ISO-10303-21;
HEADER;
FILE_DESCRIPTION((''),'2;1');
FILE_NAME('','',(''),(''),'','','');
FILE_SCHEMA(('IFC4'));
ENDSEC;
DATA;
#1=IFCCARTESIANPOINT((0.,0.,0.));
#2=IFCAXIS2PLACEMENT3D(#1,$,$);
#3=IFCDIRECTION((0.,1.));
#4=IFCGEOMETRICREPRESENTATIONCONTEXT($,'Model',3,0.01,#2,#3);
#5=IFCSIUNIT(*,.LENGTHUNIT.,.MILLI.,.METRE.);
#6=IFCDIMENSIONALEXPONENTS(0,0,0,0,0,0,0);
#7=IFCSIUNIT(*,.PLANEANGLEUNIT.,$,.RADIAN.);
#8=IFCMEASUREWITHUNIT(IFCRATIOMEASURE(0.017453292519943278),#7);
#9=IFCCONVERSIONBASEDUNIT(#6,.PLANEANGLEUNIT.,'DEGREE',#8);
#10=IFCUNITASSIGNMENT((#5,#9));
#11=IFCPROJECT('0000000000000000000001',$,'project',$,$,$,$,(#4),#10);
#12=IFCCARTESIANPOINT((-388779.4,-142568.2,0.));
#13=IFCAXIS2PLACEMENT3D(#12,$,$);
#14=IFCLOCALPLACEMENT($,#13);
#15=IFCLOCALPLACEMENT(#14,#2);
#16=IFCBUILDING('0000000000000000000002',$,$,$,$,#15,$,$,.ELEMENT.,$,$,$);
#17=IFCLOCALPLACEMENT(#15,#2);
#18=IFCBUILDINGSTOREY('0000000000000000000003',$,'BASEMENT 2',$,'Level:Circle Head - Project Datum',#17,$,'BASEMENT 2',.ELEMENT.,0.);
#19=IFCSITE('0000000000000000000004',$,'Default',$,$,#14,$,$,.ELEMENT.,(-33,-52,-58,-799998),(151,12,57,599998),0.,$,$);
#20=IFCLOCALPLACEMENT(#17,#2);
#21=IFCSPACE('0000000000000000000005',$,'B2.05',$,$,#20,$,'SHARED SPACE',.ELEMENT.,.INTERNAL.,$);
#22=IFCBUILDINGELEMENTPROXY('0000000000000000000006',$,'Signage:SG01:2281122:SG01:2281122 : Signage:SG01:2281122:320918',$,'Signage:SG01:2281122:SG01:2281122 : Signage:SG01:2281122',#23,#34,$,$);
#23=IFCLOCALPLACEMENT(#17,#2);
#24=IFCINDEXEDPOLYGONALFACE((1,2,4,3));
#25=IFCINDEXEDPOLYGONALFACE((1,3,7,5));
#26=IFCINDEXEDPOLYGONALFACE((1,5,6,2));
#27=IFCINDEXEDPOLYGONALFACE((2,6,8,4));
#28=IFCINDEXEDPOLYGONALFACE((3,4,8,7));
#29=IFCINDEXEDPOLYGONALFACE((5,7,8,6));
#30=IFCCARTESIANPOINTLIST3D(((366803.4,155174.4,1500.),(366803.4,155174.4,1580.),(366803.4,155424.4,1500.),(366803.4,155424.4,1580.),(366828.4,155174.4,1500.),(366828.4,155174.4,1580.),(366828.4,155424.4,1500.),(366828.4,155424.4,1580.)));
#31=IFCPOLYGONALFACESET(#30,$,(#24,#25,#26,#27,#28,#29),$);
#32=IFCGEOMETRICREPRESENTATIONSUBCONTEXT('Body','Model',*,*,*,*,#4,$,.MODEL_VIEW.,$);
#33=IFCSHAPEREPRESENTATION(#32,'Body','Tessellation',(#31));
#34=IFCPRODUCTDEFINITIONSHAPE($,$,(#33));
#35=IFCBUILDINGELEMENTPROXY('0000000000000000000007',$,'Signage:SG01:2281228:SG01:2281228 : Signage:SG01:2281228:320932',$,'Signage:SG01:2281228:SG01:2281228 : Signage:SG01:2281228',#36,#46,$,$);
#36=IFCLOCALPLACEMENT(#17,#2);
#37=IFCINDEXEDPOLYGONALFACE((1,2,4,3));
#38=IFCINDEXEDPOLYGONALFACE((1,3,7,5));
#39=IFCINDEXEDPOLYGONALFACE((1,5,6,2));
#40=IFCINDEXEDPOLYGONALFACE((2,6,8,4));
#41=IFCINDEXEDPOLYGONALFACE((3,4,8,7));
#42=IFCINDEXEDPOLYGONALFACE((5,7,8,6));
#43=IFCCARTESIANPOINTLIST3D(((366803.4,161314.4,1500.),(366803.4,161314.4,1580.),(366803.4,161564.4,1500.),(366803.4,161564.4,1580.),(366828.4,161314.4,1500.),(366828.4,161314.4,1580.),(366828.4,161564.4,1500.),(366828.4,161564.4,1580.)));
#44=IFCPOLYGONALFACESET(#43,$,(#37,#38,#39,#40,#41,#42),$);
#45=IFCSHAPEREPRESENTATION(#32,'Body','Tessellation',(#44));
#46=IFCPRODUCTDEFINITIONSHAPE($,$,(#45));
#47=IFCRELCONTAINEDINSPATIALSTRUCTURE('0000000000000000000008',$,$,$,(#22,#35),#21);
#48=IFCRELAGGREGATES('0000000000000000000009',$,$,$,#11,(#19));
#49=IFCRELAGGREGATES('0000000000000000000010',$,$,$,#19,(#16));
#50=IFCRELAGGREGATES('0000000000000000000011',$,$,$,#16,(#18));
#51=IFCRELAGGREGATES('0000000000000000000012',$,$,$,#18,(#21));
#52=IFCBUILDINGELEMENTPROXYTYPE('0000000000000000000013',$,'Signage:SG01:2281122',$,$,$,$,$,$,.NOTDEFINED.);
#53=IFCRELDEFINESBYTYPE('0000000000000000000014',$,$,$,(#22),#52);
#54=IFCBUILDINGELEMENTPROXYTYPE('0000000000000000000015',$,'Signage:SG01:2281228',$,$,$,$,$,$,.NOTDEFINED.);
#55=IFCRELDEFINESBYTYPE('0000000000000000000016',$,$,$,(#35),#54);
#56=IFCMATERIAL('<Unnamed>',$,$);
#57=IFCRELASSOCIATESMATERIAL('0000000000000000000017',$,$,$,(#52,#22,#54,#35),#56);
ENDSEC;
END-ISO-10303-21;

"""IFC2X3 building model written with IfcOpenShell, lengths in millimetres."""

from ifc_helpers import new_model, entity, si_unit, converted_unit, direction, frame, frame_2d, origin, place, context, subcontext, project, spatial, rectangle, extrude, source, transform, mapped, material, type_object, type_shapes, element, save


model = new_model("IFC2X3")

# Units and contexts
model_context = context("Model", 3, precision=0.01, world=origin(), true_north=direction((0.0, 1.0)))
body_context = subcontext(model_context, "Body", "Model", "MODEL_VIEW")
ifc_project = project(units=[si_unit("LENGTHUNIT", "METRE", prefix="MILLI"), converted_unit("PLANEANGLEUNIT", "DEGREE", entity("IfcRatioMeasure", 0.017453292519943278), si_unit("PLANEANGLEUNIT", "RADIAN"), dimensions=[0, 0, 0, 0, 0, 0, 0])], contexts=[model_context])

# Site, building, storey
site_placement = place(None, frame((-388779.4, -142568.2, 0.0)))
site = spatial("IfcSite", under=ifc_project, at=site_placement, Name="Default", CompositionType="ELEMENT", RefLatitude=(-33, -52, -58, -799998), RefLongitude=(151, 12, 57, 599998), RefElevation=0.0)
building_placement = place(site_placement, origin())
building = spatial("IfcBuilding", under=site, at=building_placement, CompositionType="ELEMENT")
storey_placement = place(building_placement, origin())
storey = spatial("IfcBuildingStorey", under=building, at=storey_placement, Name="BASEMENT 2", ObjectType="Level:Circle Head - Project Datum", LongName="BASEMENT 2", CompositionType="ELEMENT", Elevation=0.0)

# Shared definitions
ifc_material_1 = material(Name="<Unnamed>")

# Shared definitions
space_placement = place(storey_placement, origin())
space = spatial("IfcSpace", under=storey, at=space_placement, Name="B2.05", LongName="SHARED SPACE", CompositionType="ELEMENT", InteriorOrExteriorSpace="INTERNAL")

# Building element proxies
building_element_proxy_type_1 = type_object("IfcBuildingElementProxyType", Name="Signage:SG01:2281122", PredefinedType="NOTDEFINED", material=ifc_material_1)
shared_shape_1 = source(origin(), body_context, "Body", "SweptSolid", [
    extrude(rectangle(XDim=25.0, YDim=250.0, at=frame_2d((0.0, 0.0), x_axis=(1.0, 0.0))), frame((366815.9, 155299.4, 1500.0)), (0.0, 0.0, 1.0), 80.0),
])
type_shapes(building_element_proxy_type_1, [shared_shape_1])
proxy_1_placement = place(space_placement, origin())
element("IfcBuildingElementProxy", 1, at=proxy_1_placement, inside=space, type_object=building_element_proxy_type_1, material=ifc_material_1, Name="Signage:SG01:2281122:SG01:2281122 : Signage:SG01:2281122:320918", ObjectType="Signage:SG01:2281122:SG01:2281122 : Signage:SG01:2281122", context=body_context, shape_type="MappedRepresentation", body=[
    mapped(shared_shape_1, transform((0.0, 0.0, 0.0), scale=1.0)),
])
building_element_proxy_type_2 = type_object("IfcBuildingElementProxyType", Name="Signage:SG01:2281228", PredefinedType="NOTDEFINED", material=ifc_material_1)
shared_shape_2 = source(origin(), body_context, "Body", "SweptSolid", [
    extrude(rectangle(XDim=25.0, YDim=250.0, at=frame_2d((0.0, 0.0), x_axis=(1.0, 0.0))), frame((366815.9, 161439.4, 1500.0)), (0.0, 0.0, 1.0), 80.0),
])
type_shapes(building_element_proxy_type_2, [shared_shape_2])
proxy_2_placement = place(space_placement, origin())
element("IfcBuildingElementProxy", 2, at=proxy_2_placement, inside=space, type_object=building_element_proxy_type_2, material=ifc_material_1, Name="Signage:SG01:2281228:SG01:2281228 : Signage:SG01:2281228:320932", ObjectType="Signage:SG01:2281228:SG01:2281228 : Signage:SG01:2281228", context=body_context, shape_type="MappedRepresentation", body=[
    mapped(shared_shape_2, transform((0.0, 0.0, 0.0), scale=1.0)),
])

save(model, "model.ifc")
